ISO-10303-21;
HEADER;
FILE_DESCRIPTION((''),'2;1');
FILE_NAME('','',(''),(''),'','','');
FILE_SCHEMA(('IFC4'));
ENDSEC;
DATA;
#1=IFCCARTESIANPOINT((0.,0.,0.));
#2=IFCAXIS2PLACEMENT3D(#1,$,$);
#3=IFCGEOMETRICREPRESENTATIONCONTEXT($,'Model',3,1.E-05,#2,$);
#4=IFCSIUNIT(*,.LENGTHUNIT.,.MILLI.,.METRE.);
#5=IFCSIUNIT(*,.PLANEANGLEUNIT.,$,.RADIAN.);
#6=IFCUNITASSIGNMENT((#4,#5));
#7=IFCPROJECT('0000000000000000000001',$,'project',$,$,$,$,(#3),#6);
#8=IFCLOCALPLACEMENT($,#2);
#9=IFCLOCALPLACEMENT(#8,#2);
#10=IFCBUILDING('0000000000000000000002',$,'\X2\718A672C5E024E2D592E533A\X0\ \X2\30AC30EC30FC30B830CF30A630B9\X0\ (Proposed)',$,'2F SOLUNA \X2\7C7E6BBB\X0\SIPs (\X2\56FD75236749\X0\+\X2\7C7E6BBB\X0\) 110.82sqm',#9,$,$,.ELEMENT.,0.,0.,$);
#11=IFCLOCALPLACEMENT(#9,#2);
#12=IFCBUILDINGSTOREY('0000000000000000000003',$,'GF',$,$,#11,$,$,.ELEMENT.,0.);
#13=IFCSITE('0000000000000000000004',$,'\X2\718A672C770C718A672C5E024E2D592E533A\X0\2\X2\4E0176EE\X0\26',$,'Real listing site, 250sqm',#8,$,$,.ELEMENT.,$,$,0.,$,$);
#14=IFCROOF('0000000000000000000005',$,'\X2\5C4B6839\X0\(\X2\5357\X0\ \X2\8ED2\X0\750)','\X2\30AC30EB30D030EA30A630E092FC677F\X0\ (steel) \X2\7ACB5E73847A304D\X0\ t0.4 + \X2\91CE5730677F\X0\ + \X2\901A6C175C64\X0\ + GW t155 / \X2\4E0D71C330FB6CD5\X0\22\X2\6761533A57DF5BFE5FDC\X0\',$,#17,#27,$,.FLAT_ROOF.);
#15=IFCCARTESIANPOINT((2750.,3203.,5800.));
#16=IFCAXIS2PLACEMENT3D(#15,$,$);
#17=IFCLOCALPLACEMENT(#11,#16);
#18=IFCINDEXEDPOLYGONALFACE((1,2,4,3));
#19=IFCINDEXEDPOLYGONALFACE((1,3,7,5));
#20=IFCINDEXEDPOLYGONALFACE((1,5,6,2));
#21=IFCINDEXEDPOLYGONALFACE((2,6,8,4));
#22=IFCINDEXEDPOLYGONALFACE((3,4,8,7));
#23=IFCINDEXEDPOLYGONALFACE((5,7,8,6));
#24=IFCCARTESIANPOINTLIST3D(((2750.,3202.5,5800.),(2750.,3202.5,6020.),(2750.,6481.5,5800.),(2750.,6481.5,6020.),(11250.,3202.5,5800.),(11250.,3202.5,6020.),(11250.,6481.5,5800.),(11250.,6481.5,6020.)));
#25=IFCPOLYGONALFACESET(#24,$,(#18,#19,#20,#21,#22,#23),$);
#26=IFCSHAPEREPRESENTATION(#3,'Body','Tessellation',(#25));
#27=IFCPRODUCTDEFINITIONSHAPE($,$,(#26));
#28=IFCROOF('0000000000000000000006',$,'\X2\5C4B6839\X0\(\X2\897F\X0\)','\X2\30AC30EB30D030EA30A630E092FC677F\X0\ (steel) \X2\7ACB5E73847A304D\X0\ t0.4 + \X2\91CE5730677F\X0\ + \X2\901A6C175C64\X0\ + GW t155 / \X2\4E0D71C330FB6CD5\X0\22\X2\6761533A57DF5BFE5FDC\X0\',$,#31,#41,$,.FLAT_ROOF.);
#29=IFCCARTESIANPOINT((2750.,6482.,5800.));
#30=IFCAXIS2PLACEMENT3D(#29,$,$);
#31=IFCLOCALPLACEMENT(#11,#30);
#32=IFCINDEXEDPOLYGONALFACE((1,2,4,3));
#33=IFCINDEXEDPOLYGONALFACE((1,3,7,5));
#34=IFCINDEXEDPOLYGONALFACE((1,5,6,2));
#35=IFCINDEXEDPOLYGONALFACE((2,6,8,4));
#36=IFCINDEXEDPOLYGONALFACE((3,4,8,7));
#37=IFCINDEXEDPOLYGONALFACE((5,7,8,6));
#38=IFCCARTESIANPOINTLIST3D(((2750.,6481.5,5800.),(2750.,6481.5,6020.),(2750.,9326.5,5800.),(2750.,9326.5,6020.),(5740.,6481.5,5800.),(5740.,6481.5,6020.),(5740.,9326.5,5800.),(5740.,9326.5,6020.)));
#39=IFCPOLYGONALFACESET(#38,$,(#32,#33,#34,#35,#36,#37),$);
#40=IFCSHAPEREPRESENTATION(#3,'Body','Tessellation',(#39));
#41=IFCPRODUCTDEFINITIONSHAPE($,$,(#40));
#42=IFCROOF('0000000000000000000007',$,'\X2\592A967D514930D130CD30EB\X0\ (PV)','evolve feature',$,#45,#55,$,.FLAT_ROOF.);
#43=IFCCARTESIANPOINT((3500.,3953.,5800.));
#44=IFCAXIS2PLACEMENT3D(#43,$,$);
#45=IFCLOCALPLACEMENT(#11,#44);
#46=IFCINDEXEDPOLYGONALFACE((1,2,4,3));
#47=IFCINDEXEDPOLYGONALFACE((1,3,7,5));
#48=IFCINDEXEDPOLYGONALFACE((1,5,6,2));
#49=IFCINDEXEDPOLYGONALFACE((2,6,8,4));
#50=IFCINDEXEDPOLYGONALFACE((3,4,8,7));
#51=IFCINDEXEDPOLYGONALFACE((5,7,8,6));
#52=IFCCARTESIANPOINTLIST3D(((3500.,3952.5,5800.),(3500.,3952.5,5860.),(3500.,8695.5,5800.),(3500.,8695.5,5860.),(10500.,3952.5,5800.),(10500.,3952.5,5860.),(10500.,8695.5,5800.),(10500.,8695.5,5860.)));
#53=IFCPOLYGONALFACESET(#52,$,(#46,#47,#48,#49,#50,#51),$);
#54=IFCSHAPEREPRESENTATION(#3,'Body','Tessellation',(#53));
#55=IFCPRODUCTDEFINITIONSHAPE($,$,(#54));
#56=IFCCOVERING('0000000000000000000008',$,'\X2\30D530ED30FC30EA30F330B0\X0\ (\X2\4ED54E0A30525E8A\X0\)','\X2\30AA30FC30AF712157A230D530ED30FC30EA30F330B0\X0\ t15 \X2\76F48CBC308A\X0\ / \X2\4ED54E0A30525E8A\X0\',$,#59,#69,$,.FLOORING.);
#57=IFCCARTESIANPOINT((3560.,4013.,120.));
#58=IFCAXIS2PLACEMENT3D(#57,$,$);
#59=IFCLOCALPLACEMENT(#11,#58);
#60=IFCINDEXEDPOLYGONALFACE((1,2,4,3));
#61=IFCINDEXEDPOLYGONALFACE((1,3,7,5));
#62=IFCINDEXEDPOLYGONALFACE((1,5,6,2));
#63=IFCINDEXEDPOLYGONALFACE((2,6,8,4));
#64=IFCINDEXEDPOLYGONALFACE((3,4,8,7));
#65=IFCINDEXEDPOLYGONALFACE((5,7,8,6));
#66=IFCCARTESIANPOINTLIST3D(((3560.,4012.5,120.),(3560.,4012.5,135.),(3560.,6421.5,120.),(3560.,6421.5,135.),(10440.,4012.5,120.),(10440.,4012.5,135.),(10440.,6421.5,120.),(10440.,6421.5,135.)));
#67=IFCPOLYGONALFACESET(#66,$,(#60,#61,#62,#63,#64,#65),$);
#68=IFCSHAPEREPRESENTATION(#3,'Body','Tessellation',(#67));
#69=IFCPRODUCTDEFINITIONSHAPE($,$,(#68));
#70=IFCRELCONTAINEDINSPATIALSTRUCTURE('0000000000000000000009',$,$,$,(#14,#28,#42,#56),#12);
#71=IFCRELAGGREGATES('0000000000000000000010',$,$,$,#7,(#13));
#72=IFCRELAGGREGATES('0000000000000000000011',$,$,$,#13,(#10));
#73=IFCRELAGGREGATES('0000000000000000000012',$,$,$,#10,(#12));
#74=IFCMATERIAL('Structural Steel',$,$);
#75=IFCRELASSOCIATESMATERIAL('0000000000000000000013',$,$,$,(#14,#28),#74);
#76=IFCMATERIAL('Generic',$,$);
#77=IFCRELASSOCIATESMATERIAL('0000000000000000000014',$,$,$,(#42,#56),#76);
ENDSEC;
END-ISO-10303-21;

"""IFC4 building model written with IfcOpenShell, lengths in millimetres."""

from ifc_helpers import new_model, si_unit, frame, frame_2d, origin, place, context, project, spatial, rectangle, extrude, material, element, save


model = new_model("IFC4")

# Units and contexts
model_context = context("Model", 3, precision=1e-05, world=origin())
ifc_project = project(units=[si_unit("LENGTHUNIT", "METRE", prefix="MILLI"), si_unit("PLANEANGLEUNIT", "RADIAN")], contexts=[model_context])

# Site, building, storey
site_placement = place(None, origin())
site = spatial("IfcSite", under=ifc_project, at=site_placement, Name="熊本県熊本市中央区2丁目26", ObjectType="Real listing site, 250sqm", CompositionType="ELEMENT", RefElevation=0.0)
building_placement = place(site_placement, origin())
building = spatial("IfcBuilding", under=site, at=building_placement, Name="熊本市中央区 ガレージハウス (Proposed)", ObjectType="2F SOLUNA 籾殻SIPs (国産杉+籾殻) 110.82sqm", CompositionType="ELEMENT", ElevationOfRefHeight=0.0, ElevationOfTerrain=0.0)
storey_placement = place(building_placement, origin())
storey = spatial("IfcBuildingStorey", under=building, at=storey_placement, Name="GF", CompositionType="ELEMENT", Elevation=0.0)

# Shared definitions
ifc_material_1 = material(Name="Generic")

# Roofs
ifc_material_2 = material(Name="Structural Steel")
roof_1_placement = place(storey_placement, frame((2750.0, 3203.0, 5800.0)))
element("IfcRoof", 1, at=roof_1_placement, inside=storey, material=ifc_material_2, Name="屋根(南 軒750)", Description="ガルバリウム鋼板 (steel) 立平葺き t0.4 + 野地板 + 通気層 + GW t155 / 不燃・法22条区域対応", PredefinedType="FLAT_ROOF", context=model_context, shape_type="SweptSolid", body=[
    extrude(rectangle(XDim=8500.0, YDim=3279.0, at=frame_2d((4250.0, 1639.0))), frame((2750.0, 3203.0, 5800.0)), (0.0, 0.0, 1.0), 220.0),
])
roof_2_placement = place(storey_placement, frame((2750.0, 6482.0, 5800.0)))
element("IfcRoof", 2, at=roof_2_placement, inside=storey, material=ifc_material_2, Name="屋根(西)", Description="ガルバリウム鋼板 (steel) 立平葺き t0.4 + 野地板 + 通気層 + GW t155 / 不燃・法22条区域対応", PredefinedType="FLAT_ROOF", context=model_context, shape_type="SweptSolid", body=[
    extrude(rectangle(XDim=2990.0, YDim=2845.0, at=frame_2d((1495.0, 1422.0))), frame((2750.0, 6482.0, 5800.0)), (0.0, 0.0, 1.0), 220.0),
])
roof_3_placement = place(storey_placement, frame((3500.0, 3953.0, 5800.0)))
element("IfcRoof", 3, at=roof_3_placement, inside=storey, material=ifc_material_1, Name="太陽光パネル (PV)", Description="evolve feature", PredefinedType="FLAT_ROOF", context=model_context, shape_type="SweptSolid", body=[
    extrude(rectangle(XDim=7000.0, YDim=4743.0, at=frame_2d((3500.0, 2371.0))), frame((3500.0, 3953.0, 5800.0)), (0.0, 0.0, 1.0), 60.0),
])

# Covering
covering_placement = place(storey_placement, frame((3560.0, 4013.0, 120.0)))
element("IfcCovering", 4, at=covering_placement, inside=storey, material=ifc_material_1, Name="フローリング (仕上げ床)", Description="オーク無垢フローリング t15 直貼り / 仕上げ床", PredefinedType="FLOORING", context=model_context, shape_type="SweptSolid", body=[
    extrude(rectangle(XDim=6880.0, YDim=2409.0, at=frame_2d((3440.0, 1204.0))), frame((3560.0, 4013.0, 120.0)), (0.0, 0.0, 1.0), 15.0),
])

save(model, "model.ifc")
